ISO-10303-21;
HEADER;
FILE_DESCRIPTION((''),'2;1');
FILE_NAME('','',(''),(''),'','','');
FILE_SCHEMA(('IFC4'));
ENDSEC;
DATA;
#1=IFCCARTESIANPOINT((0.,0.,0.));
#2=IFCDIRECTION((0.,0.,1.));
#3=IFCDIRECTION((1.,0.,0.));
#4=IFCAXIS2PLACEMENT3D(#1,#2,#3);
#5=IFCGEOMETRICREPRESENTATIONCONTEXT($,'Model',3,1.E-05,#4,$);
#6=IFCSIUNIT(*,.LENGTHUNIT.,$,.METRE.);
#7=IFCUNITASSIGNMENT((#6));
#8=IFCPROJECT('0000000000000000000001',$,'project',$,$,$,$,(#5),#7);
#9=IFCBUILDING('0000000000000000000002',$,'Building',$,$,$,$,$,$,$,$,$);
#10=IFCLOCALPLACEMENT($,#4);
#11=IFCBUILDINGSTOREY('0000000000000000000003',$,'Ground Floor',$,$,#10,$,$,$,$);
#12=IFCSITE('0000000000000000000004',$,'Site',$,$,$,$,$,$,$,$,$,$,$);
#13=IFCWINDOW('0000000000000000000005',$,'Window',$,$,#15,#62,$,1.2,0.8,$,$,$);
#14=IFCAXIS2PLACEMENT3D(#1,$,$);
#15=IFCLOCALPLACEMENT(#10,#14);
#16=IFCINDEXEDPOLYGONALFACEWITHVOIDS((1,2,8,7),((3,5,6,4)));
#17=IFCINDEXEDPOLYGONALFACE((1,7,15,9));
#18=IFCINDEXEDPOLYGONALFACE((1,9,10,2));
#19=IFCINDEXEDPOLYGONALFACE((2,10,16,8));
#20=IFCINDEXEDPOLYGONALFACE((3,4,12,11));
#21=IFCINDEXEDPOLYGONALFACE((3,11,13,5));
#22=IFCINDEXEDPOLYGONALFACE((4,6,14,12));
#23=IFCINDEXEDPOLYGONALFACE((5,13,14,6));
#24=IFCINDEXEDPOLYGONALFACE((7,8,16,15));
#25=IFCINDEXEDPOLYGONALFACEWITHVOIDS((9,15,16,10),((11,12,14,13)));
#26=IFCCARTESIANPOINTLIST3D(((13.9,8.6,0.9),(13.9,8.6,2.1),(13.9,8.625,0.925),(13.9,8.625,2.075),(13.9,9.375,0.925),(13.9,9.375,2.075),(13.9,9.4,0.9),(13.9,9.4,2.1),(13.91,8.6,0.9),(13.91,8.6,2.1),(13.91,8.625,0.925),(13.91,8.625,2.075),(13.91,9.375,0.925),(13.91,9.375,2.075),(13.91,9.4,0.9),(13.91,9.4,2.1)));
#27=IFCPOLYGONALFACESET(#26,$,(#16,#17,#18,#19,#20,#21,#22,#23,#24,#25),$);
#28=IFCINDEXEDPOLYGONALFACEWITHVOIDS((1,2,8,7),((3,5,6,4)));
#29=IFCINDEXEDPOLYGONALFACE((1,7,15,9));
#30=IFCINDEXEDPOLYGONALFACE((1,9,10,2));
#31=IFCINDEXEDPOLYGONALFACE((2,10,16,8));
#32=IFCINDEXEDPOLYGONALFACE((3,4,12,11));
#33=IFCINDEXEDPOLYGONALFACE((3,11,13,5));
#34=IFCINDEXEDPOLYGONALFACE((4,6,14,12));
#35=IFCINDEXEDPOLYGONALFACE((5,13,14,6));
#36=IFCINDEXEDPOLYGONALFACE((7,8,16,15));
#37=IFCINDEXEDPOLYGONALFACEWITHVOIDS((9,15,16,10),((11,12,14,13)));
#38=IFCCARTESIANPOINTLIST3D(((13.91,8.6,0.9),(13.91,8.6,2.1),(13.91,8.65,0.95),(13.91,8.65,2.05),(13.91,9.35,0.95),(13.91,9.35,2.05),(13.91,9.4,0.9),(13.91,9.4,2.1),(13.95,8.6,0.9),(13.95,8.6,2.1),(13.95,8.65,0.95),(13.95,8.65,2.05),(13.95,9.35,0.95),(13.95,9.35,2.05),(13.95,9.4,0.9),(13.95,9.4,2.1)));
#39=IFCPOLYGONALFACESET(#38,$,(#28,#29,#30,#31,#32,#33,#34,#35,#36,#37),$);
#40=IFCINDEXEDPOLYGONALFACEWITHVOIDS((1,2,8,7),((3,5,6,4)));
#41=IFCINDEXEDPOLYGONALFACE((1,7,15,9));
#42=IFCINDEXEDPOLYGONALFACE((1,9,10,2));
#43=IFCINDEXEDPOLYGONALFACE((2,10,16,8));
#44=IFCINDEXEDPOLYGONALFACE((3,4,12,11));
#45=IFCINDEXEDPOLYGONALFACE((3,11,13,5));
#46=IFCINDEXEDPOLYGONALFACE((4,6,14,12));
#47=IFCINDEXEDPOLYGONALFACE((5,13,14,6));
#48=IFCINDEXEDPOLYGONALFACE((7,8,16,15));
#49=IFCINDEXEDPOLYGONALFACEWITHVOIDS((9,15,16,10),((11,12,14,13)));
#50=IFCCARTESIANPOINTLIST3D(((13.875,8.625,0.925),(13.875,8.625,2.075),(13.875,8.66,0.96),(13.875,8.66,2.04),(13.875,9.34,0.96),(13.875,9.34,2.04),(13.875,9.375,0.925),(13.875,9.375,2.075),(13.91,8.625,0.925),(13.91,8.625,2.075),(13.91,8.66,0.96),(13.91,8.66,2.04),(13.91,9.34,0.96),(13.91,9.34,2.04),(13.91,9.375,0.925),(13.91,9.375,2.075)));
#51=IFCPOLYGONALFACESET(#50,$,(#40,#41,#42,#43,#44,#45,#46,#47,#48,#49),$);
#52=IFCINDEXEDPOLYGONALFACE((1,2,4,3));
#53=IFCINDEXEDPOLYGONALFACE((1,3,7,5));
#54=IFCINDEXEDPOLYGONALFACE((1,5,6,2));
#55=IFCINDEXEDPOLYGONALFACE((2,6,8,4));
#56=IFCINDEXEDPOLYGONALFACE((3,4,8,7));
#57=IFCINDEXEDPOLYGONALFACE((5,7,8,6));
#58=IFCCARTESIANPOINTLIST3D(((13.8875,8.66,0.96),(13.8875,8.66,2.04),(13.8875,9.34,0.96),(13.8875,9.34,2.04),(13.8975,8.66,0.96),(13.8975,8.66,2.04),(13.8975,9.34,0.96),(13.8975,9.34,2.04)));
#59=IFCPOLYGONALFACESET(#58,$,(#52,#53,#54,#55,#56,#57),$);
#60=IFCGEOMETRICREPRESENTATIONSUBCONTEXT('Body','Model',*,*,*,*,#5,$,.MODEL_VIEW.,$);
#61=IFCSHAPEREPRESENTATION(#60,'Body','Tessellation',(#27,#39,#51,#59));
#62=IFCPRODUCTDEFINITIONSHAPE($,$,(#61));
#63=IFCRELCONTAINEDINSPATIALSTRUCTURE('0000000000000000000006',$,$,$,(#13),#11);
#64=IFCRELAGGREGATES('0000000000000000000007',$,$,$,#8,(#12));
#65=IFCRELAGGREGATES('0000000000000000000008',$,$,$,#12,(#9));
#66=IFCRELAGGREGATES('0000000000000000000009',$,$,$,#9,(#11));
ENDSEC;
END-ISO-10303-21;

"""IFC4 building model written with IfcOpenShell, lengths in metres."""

from ifc_helpers import new_model, si_unit, frame, origin_with_axes, place, context, subcontext, project, spatial, line, indexed_curve, outline, extrude, element, save


model = new_model("IFC4")

# Units and contexts
model_context = context("Model", 3, precision=1e-05, world=origin_with_axes())
body_context = subcontext(model_context, "Body", "Model", "MODEL_VIEW")
ifc_project = project(units=[si_unit("LENGTHUNIT", "METRE")], contexts=[model_context])

# Site, building, storey
site = spatial("IfcSite", under=ifc_project, Name="Site")
building = spatial("IfcBuilding", under=site, Name="Building")
storey_placement = place(None, origin_with_axes())
storey = spatial("IfcBuildingStorey", under=building, at=storey_placement, Name="Ground Floor")

# Window
window_1_placement = place(storey_placement, frame((14.0, 8.6, 0.9), z_axis=(0.0, 0.0, 1.0), x_axis=(0.0, 1.0, 0.0)))
element("IfcWindow", 1, at=window_1_placement, inside=storey, Name="Window", OverallHeight=1.2, OverallWidth=0.8, context=body_context, shape_type="SweptSolid", body=[
    extrude(outline(indexed_curve([(0.0, 0.0), (0.8, 0.0), (0.8, 1.2), (0.0, 1.2)], segments=[line(1, 2, 3, 4, 1)]), holes=[indexed_curve([(0.025, 0.025), (0.775, 0.025), (0.775, 1.175), (0.025, 1.175)], segments=[line(1, 2, 3, 4, 1)])]), frame((0.0, 0.09, 0.0), z_axis=(0.0, -1.0, 0.0), x_axis=(1.0, 0.0, 0.0)), (0.0, 0.0, -1.0), 0.01),
    extrude(outline(indexed_curve([(0.0, 0.0), (0.8, 0.0), (0.8, 1.2), (0.0, 1.2)], segments=[line(1, 2, 3, 4, 1)]), holes=[indexed_curve([(0.05, 0.05), (0.75, 0.05), (0.75, 1.15), (0.05, 1.15)], segments=[line(1, 2, 3, 4, 1)])]), frame((0.0, 0.05, 0.0), z_axis=(0.0, -1.0, 0.0), x_axis=(1.0, 0.0, 0.0)), (0.0, 0.0, -1.0), 0.04),
    extrude(outline(indexed_curve([(0.0, 0.0), (0.75, 0.0), (0.75, 1.15), (0.0, 1.15)], segments=[line(1, 2, 3, 4, 1)]), holes=[indexed_curve([(0.035, 0.035), (0.715, 0.035), (0.715, 1.115), (0.035, 1.115)], segments=[line(1, 2, 3, 4, 1)])]), frame((0.025, 0.09, 0.025), z_axis=(0.0, -1.0, 0.0), x_axis=(1.0, 0.0, 0.0)), (0.0, 0.0, -1.0), 0.035),
    extrude(outline(indexed_curve([(0.035, 0.035), (0.715, 0.035), (0.715, 1.115), (0.035, 1.115)], segments=[line(1, 2, 3, 4, 1)])), frame((0.025, 0.1025, 0.025), z_axis=(0.0, -1.0, 0.0), x_axis=(1.0, 0.0, 0.0)), (0.0, 0.0, -1.0), 0.01),
])

save(model, "model.ifc")
